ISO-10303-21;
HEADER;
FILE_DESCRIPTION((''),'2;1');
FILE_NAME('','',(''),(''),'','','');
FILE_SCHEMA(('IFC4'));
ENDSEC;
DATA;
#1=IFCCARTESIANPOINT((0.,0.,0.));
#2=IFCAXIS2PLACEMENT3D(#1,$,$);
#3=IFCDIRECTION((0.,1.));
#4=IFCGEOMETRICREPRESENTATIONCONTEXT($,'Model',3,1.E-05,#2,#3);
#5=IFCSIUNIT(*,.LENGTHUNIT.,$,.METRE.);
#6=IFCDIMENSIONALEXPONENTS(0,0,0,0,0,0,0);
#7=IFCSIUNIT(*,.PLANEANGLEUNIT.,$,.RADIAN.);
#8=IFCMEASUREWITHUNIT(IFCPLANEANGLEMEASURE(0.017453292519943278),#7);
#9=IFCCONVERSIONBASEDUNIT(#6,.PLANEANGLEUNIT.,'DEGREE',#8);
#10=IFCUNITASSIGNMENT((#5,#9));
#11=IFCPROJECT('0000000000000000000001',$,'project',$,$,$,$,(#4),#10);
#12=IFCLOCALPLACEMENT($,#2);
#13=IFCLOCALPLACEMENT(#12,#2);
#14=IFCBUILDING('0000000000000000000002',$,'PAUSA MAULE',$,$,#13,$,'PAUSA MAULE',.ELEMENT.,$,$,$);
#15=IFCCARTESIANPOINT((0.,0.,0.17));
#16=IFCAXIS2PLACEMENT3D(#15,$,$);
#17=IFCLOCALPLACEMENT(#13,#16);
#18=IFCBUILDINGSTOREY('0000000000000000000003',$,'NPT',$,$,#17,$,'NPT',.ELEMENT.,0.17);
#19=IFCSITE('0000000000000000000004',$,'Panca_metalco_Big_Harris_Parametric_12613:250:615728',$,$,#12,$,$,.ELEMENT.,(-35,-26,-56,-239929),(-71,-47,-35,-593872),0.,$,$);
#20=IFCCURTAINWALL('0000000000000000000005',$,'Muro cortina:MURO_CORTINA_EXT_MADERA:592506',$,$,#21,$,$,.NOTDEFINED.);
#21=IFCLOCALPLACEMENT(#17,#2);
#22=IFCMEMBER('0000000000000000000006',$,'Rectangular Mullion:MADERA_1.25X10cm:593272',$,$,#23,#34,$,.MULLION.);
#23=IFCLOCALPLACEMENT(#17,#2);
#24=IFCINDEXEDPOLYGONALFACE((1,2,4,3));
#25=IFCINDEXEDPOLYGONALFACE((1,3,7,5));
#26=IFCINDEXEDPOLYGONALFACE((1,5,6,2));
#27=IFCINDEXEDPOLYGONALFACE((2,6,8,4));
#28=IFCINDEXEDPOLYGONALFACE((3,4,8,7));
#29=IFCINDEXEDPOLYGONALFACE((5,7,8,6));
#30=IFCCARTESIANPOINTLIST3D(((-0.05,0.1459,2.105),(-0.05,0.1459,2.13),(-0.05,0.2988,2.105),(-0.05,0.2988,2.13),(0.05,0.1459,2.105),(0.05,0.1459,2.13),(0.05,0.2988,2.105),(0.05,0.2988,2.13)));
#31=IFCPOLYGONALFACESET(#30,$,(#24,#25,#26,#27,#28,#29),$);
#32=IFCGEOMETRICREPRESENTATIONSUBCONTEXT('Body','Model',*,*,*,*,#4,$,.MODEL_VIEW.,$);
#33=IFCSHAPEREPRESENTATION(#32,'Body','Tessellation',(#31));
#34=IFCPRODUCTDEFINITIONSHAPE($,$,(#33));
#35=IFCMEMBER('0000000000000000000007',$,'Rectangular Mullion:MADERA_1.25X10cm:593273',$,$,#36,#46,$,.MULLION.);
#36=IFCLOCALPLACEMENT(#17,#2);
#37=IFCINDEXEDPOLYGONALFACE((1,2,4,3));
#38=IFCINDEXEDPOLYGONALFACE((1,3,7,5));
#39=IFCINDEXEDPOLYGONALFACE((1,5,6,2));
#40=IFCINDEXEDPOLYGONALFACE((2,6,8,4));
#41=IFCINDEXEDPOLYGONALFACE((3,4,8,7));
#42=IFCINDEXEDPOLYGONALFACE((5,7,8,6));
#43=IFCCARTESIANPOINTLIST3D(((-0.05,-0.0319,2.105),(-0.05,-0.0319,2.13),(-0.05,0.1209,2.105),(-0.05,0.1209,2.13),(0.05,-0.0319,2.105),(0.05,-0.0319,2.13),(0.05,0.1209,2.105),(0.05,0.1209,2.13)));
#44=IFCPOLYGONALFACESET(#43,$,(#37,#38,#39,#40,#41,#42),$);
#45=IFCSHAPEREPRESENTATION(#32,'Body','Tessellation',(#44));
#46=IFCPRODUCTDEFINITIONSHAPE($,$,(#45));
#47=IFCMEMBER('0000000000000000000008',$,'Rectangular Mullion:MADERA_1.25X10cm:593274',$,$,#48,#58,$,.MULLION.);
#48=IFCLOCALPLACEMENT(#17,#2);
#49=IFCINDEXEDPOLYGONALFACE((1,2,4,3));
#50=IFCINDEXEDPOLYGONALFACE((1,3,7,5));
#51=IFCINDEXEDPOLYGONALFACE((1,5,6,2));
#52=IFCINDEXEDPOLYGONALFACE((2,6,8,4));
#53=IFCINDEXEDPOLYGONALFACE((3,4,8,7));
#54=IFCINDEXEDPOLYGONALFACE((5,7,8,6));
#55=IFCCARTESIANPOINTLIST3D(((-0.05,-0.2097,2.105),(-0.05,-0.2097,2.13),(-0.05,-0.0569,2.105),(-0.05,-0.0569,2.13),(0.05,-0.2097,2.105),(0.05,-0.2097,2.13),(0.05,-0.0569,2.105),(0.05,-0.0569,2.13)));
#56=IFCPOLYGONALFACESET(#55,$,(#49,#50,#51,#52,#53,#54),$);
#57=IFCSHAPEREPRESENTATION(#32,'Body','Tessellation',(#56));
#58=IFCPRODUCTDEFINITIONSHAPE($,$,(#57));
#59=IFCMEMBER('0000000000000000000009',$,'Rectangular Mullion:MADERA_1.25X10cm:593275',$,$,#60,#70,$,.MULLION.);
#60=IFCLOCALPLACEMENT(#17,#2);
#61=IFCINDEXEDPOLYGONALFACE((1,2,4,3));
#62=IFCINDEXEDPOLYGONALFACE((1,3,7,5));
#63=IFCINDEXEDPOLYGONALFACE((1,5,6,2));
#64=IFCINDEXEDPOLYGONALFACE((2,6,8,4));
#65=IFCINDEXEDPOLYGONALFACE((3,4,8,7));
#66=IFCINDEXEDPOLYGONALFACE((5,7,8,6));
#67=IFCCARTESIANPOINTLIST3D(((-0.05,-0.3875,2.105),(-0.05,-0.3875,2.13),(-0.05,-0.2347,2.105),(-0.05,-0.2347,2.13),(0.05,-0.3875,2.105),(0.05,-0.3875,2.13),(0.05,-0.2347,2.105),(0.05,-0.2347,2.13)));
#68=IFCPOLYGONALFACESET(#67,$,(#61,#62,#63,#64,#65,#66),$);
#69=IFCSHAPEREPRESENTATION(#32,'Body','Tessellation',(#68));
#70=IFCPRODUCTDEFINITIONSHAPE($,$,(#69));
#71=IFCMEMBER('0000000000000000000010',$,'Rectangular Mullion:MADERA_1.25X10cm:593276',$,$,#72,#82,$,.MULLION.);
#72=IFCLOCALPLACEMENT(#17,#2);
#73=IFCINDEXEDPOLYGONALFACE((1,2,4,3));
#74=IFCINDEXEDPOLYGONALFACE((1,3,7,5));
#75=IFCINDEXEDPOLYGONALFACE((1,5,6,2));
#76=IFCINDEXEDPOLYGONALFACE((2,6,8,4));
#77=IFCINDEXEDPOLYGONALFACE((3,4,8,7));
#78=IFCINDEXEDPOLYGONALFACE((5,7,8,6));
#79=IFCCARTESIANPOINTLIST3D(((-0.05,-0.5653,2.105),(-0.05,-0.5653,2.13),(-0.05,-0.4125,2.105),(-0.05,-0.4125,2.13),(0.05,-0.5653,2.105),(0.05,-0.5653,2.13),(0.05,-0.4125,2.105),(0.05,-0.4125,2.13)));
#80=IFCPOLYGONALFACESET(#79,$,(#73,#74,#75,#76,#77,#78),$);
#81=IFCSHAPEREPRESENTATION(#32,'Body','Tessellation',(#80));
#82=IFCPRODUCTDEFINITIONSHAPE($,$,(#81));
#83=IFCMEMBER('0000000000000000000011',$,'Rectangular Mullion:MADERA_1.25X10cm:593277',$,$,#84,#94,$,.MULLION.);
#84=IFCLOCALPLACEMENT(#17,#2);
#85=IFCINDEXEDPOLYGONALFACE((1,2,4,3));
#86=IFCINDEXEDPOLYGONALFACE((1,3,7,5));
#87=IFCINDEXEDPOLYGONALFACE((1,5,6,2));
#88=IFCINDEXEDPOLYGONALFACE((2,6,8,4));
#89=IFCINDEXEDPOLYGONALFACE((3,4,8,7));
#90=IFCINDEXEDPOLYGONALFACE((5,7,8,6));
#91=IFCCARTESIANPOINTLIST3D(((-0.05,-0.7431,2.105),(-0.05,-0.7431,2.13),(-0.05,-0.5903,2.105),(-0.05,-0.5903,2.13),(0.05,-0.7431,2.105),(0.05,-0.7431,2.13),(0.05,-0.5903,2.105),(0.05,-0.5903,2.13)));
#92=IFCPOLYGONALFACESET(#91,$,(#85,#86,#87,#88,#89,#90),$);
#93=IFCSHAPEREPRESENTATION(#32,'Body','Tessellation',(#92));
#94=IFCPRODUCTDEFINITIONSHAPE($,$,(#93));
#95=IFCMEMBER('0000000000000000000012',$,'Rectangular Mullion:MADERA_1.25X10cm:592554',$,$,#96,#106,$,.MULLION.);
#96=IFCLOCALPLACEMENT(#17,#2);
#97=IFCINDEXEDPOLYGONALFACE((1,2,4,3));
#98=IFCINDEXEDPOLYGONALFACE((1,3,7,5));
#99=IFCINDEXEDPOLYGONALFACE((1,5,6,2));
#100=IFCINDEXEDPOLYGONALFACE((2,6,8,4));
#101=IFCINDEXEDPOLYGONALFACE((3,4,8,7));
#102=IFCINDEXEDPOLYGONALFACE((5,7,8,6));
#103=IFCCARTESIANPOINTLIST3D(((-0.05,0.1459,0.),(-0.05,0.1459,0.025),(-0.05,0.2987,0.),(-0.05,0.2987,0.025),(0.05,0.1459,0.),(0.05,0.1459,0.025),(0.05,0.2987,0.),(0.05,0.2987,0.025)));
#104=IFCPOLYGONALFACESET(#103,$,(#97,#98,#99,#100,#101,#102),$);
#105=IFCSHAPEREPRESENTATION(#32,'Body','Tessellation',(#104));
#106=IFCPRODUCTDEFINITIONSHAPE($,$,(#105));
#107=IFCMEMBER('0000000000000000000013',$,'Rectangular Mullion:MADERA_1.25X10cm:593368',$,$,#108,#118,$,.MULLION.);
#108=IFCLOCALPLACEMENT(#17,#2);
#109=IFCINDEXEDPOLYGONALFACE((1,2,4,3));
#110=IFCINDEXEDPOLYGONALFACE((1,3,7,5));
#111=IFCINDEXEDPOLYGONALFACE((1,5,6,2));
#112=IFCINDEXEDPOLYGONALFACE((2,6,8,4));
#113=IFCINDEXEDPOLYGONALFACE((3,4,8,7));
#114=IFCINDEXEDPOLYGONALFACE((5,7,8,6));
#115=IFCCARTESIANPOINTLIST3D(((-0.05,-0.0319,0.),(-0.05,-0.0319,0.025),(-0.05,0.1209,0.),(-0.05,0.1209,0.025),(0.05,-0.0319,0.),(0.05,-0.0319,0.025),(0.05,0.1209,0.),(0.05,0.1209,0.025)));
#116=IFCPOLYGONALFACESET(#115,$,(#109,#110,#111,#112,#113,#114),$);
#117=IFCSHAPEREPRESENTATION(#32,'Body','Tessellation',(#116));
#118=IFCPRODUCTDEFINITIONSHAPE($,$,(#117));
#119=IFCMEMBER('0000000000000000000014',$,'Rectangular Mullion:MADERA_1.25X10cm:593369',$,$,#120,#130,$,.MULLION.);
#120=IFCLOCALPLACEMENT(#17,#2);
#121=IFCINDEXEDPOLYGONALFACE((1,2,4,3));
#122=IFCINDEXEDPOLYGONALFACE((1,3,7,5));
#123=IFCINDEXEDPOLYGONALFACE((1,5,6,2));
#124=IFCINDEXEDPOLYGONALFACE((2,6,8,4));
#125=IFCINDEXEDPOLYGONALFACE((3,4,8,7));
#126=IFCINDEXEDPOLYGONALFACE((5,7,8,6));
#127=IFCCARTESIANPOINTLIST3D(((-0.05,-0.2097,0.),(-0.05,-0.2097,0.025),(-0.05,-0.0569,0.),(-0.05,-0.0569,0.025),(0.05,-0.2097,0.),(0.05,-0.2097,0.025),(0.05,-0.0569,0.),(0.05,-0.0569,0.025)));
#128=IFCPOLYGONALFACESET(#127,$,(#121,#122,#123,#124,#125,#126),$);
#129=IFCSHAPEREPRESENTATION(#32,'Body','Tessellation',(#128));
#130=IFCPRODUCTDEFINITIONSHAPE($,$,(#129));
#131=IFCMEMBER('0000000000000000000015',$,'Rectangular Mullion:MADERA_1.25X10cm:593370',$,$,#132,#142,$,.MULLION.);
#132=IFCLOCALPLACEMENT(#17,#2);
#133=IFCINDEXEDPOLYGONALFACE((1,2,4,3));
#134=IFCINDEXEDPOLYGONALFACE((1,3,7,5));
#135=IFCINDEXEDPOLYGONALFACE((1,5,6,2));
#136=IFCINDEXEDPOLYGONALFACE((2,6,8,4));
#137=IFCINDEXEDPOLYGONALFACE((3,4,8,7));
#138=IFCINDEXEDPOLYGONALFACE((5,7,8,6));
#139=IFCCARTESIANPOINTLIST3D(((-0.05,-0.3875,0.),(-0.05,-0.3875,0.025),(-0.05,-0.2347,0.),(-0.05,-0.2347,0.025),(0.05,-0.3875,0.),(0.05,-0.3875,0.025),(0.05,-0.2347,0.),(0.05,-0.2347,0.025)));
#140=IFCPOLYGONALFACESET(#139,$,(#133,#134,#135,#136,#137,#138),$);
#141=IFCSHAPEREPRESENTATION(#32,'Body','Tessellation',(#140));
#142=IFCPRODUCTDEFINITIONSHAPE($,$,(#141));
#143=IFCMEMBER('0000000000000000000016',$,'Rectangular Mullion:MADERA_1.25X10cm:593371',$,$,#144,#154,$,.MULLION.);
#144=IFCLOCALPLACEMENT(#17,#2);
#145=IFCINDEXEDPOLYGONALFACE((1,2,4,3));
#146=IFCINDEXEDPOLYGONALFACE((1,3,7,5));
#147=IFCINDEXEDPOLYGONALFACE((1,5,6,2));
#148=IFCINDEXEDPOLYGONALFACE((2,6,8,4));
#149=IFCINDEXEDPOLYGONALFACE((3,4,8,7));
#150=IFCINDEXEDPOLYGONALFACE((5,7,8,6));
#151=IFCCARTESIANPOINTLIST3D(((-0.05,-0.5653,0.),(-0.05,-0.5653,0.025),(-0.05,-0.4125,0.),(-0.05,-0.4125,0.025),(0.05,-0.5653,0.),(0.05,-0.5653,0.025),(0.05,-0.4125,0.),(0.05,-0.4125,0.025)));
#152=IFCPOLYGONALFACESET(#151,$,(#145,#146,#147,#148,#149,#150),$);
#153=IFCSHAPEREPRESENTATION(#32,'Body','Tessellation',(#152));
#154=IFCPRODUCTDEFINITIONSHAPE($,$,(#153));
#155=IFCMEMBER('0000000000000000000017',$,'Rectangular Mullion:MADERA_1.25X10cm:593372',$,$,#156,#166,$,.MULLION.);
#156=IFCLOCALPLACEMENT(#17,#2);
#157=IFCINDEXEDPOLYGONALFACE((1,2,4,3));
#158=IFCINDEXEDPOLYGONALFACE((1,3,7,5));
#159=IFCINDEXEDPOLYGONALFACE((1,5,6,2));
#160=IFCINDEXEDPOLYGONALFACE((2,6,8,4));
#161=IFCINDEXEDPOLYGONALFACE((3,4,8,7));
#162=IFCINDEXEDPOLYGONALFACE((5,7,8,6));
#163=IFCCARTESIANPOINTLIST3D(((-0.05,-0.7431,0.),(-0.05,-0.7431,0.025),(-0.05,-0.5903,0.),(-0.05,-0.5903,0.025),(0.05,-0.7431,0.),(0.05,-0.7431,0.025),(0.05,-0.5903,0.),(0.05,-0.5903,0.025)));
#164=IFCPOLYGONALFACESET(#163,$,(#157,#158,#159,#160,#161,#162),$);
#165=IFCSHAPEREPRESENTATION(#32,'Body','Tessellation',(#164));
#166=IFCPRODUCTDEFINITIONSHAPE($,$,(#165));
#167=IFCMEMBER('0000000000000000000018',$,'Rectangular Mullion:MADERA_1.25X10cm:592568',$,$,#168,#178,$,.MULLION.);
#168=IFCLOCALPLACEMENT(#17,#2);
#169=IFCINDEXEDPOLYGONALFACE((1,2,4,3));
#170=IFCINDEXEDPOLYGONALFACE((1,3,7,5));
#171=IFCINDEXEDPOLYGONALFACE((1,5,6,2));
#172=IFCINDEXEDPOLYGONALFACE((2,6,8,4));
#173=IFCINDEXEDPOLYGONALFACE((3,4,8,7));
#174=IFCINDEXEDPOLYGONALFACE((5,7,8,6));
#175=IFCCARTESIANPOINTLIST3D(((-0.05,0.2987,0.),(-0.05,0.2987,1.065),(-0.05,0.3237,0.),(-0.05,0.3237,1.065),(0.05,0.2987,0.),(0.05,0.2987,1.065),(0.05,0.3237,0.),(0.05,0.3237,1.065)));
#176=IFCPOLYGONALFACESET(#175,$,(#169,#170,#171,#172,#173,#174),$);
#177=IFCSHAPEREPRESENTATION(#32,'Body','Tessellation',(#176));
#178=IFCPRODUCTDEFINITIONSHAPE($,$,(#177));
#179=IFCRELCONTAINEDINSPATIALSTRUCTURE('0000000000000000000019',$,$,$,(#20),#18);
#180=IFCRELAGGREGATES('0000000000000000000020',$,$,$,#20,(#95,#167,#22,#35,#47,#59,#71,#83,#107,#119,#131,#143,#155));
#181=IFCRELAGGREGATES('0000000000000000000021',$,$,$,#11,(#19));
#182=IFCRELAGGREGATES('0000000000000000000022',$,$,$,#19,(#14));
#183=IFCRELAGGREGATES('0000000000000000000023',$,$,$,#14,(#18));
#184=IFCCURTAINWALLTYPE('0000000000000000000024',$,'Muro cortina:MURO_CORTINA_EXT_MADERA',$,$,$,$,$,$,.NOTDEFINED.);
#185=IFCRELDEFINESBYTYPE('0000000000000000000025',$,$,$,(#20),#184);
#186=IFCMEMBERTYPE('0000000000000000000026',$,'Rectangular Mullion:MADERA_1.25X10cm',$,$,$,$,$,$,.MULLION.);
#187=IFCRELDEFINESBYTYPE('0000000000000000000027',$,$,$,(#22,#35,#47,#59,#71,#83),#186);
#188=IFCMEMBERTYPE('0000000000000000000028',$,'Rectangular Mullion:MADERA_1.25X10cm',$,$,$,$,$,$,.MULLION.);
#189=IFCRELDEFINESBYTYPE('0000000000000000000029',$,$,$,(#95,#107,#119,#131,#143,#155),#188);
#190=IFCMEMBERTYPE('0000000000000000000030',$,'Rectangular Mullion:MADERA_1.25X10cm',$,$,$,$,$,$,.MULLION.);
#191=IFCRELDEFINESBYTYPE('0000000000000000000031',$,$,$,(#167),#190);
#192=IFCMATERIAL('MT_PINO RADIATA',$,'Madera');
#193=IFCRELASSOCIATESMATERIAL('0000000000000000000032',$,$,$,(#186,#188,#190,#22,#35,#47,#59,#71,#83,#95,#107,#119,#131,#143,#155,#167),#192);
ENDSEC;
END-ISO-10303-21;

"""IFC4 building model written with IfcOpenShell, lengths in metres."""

from ifc_helpers import new_model, entity, si_unit, converted_unit, direction, frame, frame_2d, origin, place, context, subcontext, project, spatial, rectangle, extrude, source, transform, mapped, material, material_profile, profile_set, profile_usage, type_object, type_shapes, element, aggregate, save


model = new_model("IFC4")

# Units and contexts
model_context = context("Model", 3, precision=1e-05, world=origin(), true_north=direction((0.0, 1.0)))
body_context = subcontext(model_context, "Body", "Model", "MODEL_VIEW")
ifc_project = project(units=[si_unit("LENGTHUNIT", "METRE"), converted_unit("PLANEANGLEUNIT", "DEGREE", entity("IfcPlaneAngleMeasure", 0.017453292519943278), si_unit("PLANEANGLEUNIT", "RADIAN"), dimensions=[0, 0, 0, 0, 0, 0, 0])], contexts=[model_context])

# Site, building, storey
site_placement = place(None, origin())
site = spatial("IfcSite", under=ifc_project, at=site_placement, Name="Panca_metalco_Big_Harris_Parametric_12613:250:615728", CompositionType="ELEMENT", RefLatitude=(-35, -26, -56, -239929), RefLongitude=(-71, -47, -35, -593872), RefElevation=0.0)
building_placement = place(site_placement, origin())
building = spatial("IfcBuilding", under=site, at=building_placement, Name="PAUSA MAULE", LongName="PAUSA MAULE", CompositionType="ELEMENT")
storey_placement = place(building_placement, frame((0.0, 0.0, 0.17)))
storey = spatial("IfcBuildingStorey", under=building, at=storey_placement, Name="NPT", LongName="NPT", CompositionType="ELEMENT", Elevation=0.17)

# Curtain wall, members
curtain_wall_type = type_object("IfcCurtainWallType", Name="Muro cortina:MURO_CORTINA_EXT_MADERA", PredefinedType="NOTDEFINED")
curtain_wall_placement = place(storey_placement, frame((0.0, 0.0, -0.17)))
curtain_wall = element("IfcCurtainWall", 1, at=curtain_wall_placement, inside=storey, type_object=curtain_wall_type, Name="Muro cortina:MURO_CORTINA_EXT_MADERA:592506", PredefinedType="NOTDEFINED")
ifc_material_1 = material(Name="MT_PINO RADIATA", Category="Madera")
ifc_material_profile = material_profile(ifc_material_1, rectangle(XDim=0.025, YDim=0.1, at=frame_2d((0.0, 0.0), x_axis=(1.0, 0.0))), Name="MADERA_1.25X10cm")
ifc_profile_set = profile_set([ifc_material_profile], Name="MADERA_1.25X10cm")
ifc_profile_usage = profile_usage(ifc_profile_set)
member_type_1 = type_object("IfcMemberType", Name="Rectangular Mullion:MADERA_1.25X10cm", PredefinedType="MULLION", material=ifc_profile_set)
shared_shape_1 = source(origin(), body_context, "Body", "SweptSolid", [
    extrude(rectangle(XDim=0.025, YDim=0.1, at=frame_2d((0.0, 0.0), x_axis=(1.0, 0.0))), frame((-0.0125, 0.0, -0.1528), z_axis=(0.0, 0.0, 1.0), x_axis=(-1.0, 0.0, 0.0)), (0.0, 0.0, 1.0), 0.1528),
])
type_shapes(member_type_1, [shared_shape_1])
member_1_placement = place(curtain_wall_placement, frame((0.0, 0.1459, 2.3), z_axis=(0.0, -1.0, 0.0), x_axis=(0.0, 0.0, 1.0)))
member_1 = element("IfcMember", 2, at=member_1_placement, type_object=member_type_1, material=ifc_profile_usage, Name="Rectangular Mullion:MADERA_1.25X10cm:593272", PredefinedType="MULLION", context=body_context, shape_type="MappedRepresentation", body=[
    mapped(shared_shape_1, transform((0.0, 0.0, 0.0), scale=1.0)),
])
member_2_placement = place(curtain_wall_placement, frame((0.0, -0.0319, 2.3), z_axis=(0.0, -1.0, 0.0), x_axis=(0.0, 0.0, 1.0)))
member_2 = element("IfcMember", 3, at=member_2_placement, type_object=member_type_1, material=ifc_profile_usage, Name="Rectangular Mullion:MADERA_1.25X10cm:593273", PredefinedType="MULLION", context=body_context, shape_type="MappedRepresentation", body=[
    mapped(shared_shape_1, transform((0.0, 0.0, 0.0), scale=1.0)),
])
member_3_placement = place(curtain_wall_placement, frame((0.0, -0.2097, 2.3), z_axis=(0.0, -1.0, 0.0), x_axis=(0.0, 0.0, 1.0)))
member_3 = element("IfcMember", 4, at=member_3_placement, type_object=member_type_1, material=ifc_profile_usage, Name="Rectangular Mullion:MADERA_1.25X10cm:593274", PredefinedType="MULLION", context=body_context, shape_type="MappedRepresentation", body=[
    mapped(shared_shape_1, transform((0.0, 0.0, 0.0), scale=1.0)),
])
member_4_placement = place(curtain_wall_placement, frame((0.0, -0.3875, 2.3), z_axis=(0.0, -1.0, 0.0), x_axis=(0.0, 0.0, 1.0)))
member_4 = element("IfcMember", 5, at=member_4_placement, type_object=member_type_1, material=ifc_profile_usage, Name="Rectangular Mullion:MADERA_1.25X10cm:593275", PredefinedType="MULLION", context=body_context, shape_type="MappedRepresentation", body=[
    mapped(shared_shape_1, transform((0.0, 0.0, 0.0), scale=1.0)),
])
member_5_placement = place(curtain_wall_placement, frame((0.0, -0.5653, 2.3), z_axis=(0.0, -1.0, 0.0), x_axis=(0.0, 0.0, 1.0)))
member_5 = element("IfcMember", 6, at=member_5_placement, type_object=member_type_1, material=ifc_profile_usage, Name="Rectangular Mullion:MADERA_1.25X10cm:593276", PredefinedType="MULLION", context=body_context, shape_type="MappedRepresentation", body=[
    mapped(shared_shape_1, transform((0.0, 0.0, 0.0), scale=1.0)),
])
member_6_placement = place(curtain_wall_placement, frame((0.0, -0.7431, 2.3), z_axis=(0.0, -1.0, 0.0), x_axis=(0.0, 0.0, 1.0)))
member_6 = element("IfcMember", 7, at=member_6_placement, type_object=member_type_1, material=ifc_profile_usage, Name="Rectangular Mullion:MADERA_1.25X10cm:593277", PredefinedType="MULLION", context=body_context, shape_type="MappedRepresentation", body=[
    mapped(shared_shape_1, transform((0.0, 0.0, 0.0), scale=1.0)),
])
member_type_2 = type_object("IfcMemberType", Name="Rectangular Mullion:MADERA_1.25X10cm", PredefinedType="MULLION", material=ifc_profile_set)
shared_shape_2 = source(origin(), body_context, "Body", "SweptSolid", [
    extrude(rectangle(XDim=0.025, YDim=0.1, at=frame_2d((0.0, 0.0), x_axis=(1.0, 0.0))), frame((-0.0125, 0.0, -0.1528), z_axis=(0.0, 0.0, 1.0), x_axis=(-1.0, 0.0, 0.0)), (0.0, 0.0, 1.0), 0.1528),
])
type_shapes(member_type_2, [shared_shape_2])
member_7_placement = place(curtain_wall_placement, frame((0.0, 0.2987, 0.17), z_axis=(0.0, 1.0, 0.0), x_axis=(0.0, 0.0, -1.0)))
member_7 = element("IfcMember", 8, at=member_7_placement, type_object=member_type_2, material=ifc_profile_usage, Name="Rectangular Mullion:MADERA_1.25X10cm:592554", PredefinedType="MULLION", context=body_context, shape_type="MappedRepresentation", body=[
    mapped(shared_shape_2, transform((0.0, 0.0, 0.0), scale=1.0)),
])
member_8_placement = place(curtain_wall_placement, frame((0.0, 0.1209, 0.17), z_axis=(0.0, 1.0, 0.0), x_axis=(0.0, 0.0, -1.0)))
member_8 = element("IfcMember", 9, at=member_8_placement, type_object=member_type_2, material=ifc_profile_usage, Name="Rectangular Mullion:MADERA_1.25X10cm:593368", PredefinedType="MULLION", context=body_context, shape_type="MappedRepresentation", body=[
    mapped(shared_shape_2, transform((0.0, 0.0, 0.0), scale=1.0)),
])
member_9_placement = place(curtain_wall_placement, frame((0.0, -0.0569, 0.17), z_axis=(0.0, 1.0, 0.0), x_axis=(0.0, 0.0, -1.0)))
member_9 = element("IfcMember", 10, at=member_9_placement, type_object=member_type_2, material=ifc_profile_usage, Name="Rectangular Mullion:MADERA_1.25X10cm:593369", PredefinedType="MULLION", context=body_context, shape_type="MappedRepresentation", body=[
    mapped(shared_shape_2, transform((0.0, 0.0, 0.0), scale=1.0)),
])
member_10_placement = place(curtain_wall_placement, frame((0.0, -0.2347, 0.17), z_axis=(0.0, 1.0, 0.0), x_axis=(0.0, 0.0, -1.0)))
member_10 = element("IfcMember", 11, at=member_10_placement, type_object=member_type_2, material=ifc_profile_usage, Name="Rectangular Mullion:MADERA_1.25X10cm:593370", PredefinedType="MULLION", context=body_context, shape_type="MappedRepresentation", body=[
    mapped(shared_shape_2, transform((0.0, 0.0, 0.0), scale=1.0)),
])
member_11_placement = place(curtain_wall_placement, frame((0.0, -0.4125, 0.17), z_axis=(0.0, 1.0, 0.0), x_axis=(0.0, 0.0, -1.0)))
member_11 = element("IfcMember", 12, at=member_11_placement, type_object=member_type_2, material=ifc_profile_usage, Name="Rectangular Mullion:MADERA_1.25X10cm:593371", PredefinedType="MULLION", context=body_context, shape_type="MappedRepresentation", body=[
    mapped(shared_shape_2, transform((0.0, 0.0, 0.0), scale=1.0)),
])
member_12_placement = place(curtain_wall_placement, frame((0.0, -0.5903, 0.17), z_axis=(0.0, 1.0, 0.0), x_axis=(0.0, 0.0, -1.0)))
member_12 = element("IfcMember", 13, at=member_12_placement, type_object=member_type_2, material=ifc_profile_usage, Name="Rectangular Mullion:MADERA_1.25X10cm:593372", PredefinedType="MULLION", context=body_context, shape_type="MappedRepresentation", body=[
    mapped(shared_shape_2, transform((0.0, 0.0, 0.0), scale=1.0)),
])
member_type_3 = type_object("IfcMemberType", Name="Rectangular Mullion:MADERA_1.25X10cm", PredefinedType="MULLION", material=ifc_profile_set)
shared_shape_3 = source(origin(), body_context, "Body", "SweptSolid", [
    extrude(rectangle(XDim=0.025, YDim=0.1, at=frame_2d((0.0, 0.0), x_axis=(1.0, 0.0))), frame((0.0, 0.0, -1.065), z_axis=(0.0, 0.0, 1.0), x_axis=(-1.0, 0.0, 0.0)), (0.0, 0.0, 1.0), 1.065),
])
type_shapes(member_type_3, [shared_shape_3])
member_13_placement = place(curtain_wall_placement, frame((0.0, 0.3112, 0.17), z_axis=(0.0, 0.0, -1.0), x_axis=(0.0, -1.0, 0.0)))
member_13 = element("IfcMember", 14, at=member_13_placement, type_object=member_type_3, material=ifc_profile_usage, Name="Rectangular Mullion:MADERA_1.25X10cm:592568", PredefinedType="MULLION", context=body_context, shape_type="MappedRepresentation", body=[
    mapped(shared_shape_3, transform((0.0, 0.0, 0.0), scale=1.0)),
])
aggregate(curtain_wall, [member_7, member_13, member_1, member_2, member_3, member_4, member_5, member_6, member_8, member_9, member_10, member_11, member_12])

save(model, "model.ifc")
